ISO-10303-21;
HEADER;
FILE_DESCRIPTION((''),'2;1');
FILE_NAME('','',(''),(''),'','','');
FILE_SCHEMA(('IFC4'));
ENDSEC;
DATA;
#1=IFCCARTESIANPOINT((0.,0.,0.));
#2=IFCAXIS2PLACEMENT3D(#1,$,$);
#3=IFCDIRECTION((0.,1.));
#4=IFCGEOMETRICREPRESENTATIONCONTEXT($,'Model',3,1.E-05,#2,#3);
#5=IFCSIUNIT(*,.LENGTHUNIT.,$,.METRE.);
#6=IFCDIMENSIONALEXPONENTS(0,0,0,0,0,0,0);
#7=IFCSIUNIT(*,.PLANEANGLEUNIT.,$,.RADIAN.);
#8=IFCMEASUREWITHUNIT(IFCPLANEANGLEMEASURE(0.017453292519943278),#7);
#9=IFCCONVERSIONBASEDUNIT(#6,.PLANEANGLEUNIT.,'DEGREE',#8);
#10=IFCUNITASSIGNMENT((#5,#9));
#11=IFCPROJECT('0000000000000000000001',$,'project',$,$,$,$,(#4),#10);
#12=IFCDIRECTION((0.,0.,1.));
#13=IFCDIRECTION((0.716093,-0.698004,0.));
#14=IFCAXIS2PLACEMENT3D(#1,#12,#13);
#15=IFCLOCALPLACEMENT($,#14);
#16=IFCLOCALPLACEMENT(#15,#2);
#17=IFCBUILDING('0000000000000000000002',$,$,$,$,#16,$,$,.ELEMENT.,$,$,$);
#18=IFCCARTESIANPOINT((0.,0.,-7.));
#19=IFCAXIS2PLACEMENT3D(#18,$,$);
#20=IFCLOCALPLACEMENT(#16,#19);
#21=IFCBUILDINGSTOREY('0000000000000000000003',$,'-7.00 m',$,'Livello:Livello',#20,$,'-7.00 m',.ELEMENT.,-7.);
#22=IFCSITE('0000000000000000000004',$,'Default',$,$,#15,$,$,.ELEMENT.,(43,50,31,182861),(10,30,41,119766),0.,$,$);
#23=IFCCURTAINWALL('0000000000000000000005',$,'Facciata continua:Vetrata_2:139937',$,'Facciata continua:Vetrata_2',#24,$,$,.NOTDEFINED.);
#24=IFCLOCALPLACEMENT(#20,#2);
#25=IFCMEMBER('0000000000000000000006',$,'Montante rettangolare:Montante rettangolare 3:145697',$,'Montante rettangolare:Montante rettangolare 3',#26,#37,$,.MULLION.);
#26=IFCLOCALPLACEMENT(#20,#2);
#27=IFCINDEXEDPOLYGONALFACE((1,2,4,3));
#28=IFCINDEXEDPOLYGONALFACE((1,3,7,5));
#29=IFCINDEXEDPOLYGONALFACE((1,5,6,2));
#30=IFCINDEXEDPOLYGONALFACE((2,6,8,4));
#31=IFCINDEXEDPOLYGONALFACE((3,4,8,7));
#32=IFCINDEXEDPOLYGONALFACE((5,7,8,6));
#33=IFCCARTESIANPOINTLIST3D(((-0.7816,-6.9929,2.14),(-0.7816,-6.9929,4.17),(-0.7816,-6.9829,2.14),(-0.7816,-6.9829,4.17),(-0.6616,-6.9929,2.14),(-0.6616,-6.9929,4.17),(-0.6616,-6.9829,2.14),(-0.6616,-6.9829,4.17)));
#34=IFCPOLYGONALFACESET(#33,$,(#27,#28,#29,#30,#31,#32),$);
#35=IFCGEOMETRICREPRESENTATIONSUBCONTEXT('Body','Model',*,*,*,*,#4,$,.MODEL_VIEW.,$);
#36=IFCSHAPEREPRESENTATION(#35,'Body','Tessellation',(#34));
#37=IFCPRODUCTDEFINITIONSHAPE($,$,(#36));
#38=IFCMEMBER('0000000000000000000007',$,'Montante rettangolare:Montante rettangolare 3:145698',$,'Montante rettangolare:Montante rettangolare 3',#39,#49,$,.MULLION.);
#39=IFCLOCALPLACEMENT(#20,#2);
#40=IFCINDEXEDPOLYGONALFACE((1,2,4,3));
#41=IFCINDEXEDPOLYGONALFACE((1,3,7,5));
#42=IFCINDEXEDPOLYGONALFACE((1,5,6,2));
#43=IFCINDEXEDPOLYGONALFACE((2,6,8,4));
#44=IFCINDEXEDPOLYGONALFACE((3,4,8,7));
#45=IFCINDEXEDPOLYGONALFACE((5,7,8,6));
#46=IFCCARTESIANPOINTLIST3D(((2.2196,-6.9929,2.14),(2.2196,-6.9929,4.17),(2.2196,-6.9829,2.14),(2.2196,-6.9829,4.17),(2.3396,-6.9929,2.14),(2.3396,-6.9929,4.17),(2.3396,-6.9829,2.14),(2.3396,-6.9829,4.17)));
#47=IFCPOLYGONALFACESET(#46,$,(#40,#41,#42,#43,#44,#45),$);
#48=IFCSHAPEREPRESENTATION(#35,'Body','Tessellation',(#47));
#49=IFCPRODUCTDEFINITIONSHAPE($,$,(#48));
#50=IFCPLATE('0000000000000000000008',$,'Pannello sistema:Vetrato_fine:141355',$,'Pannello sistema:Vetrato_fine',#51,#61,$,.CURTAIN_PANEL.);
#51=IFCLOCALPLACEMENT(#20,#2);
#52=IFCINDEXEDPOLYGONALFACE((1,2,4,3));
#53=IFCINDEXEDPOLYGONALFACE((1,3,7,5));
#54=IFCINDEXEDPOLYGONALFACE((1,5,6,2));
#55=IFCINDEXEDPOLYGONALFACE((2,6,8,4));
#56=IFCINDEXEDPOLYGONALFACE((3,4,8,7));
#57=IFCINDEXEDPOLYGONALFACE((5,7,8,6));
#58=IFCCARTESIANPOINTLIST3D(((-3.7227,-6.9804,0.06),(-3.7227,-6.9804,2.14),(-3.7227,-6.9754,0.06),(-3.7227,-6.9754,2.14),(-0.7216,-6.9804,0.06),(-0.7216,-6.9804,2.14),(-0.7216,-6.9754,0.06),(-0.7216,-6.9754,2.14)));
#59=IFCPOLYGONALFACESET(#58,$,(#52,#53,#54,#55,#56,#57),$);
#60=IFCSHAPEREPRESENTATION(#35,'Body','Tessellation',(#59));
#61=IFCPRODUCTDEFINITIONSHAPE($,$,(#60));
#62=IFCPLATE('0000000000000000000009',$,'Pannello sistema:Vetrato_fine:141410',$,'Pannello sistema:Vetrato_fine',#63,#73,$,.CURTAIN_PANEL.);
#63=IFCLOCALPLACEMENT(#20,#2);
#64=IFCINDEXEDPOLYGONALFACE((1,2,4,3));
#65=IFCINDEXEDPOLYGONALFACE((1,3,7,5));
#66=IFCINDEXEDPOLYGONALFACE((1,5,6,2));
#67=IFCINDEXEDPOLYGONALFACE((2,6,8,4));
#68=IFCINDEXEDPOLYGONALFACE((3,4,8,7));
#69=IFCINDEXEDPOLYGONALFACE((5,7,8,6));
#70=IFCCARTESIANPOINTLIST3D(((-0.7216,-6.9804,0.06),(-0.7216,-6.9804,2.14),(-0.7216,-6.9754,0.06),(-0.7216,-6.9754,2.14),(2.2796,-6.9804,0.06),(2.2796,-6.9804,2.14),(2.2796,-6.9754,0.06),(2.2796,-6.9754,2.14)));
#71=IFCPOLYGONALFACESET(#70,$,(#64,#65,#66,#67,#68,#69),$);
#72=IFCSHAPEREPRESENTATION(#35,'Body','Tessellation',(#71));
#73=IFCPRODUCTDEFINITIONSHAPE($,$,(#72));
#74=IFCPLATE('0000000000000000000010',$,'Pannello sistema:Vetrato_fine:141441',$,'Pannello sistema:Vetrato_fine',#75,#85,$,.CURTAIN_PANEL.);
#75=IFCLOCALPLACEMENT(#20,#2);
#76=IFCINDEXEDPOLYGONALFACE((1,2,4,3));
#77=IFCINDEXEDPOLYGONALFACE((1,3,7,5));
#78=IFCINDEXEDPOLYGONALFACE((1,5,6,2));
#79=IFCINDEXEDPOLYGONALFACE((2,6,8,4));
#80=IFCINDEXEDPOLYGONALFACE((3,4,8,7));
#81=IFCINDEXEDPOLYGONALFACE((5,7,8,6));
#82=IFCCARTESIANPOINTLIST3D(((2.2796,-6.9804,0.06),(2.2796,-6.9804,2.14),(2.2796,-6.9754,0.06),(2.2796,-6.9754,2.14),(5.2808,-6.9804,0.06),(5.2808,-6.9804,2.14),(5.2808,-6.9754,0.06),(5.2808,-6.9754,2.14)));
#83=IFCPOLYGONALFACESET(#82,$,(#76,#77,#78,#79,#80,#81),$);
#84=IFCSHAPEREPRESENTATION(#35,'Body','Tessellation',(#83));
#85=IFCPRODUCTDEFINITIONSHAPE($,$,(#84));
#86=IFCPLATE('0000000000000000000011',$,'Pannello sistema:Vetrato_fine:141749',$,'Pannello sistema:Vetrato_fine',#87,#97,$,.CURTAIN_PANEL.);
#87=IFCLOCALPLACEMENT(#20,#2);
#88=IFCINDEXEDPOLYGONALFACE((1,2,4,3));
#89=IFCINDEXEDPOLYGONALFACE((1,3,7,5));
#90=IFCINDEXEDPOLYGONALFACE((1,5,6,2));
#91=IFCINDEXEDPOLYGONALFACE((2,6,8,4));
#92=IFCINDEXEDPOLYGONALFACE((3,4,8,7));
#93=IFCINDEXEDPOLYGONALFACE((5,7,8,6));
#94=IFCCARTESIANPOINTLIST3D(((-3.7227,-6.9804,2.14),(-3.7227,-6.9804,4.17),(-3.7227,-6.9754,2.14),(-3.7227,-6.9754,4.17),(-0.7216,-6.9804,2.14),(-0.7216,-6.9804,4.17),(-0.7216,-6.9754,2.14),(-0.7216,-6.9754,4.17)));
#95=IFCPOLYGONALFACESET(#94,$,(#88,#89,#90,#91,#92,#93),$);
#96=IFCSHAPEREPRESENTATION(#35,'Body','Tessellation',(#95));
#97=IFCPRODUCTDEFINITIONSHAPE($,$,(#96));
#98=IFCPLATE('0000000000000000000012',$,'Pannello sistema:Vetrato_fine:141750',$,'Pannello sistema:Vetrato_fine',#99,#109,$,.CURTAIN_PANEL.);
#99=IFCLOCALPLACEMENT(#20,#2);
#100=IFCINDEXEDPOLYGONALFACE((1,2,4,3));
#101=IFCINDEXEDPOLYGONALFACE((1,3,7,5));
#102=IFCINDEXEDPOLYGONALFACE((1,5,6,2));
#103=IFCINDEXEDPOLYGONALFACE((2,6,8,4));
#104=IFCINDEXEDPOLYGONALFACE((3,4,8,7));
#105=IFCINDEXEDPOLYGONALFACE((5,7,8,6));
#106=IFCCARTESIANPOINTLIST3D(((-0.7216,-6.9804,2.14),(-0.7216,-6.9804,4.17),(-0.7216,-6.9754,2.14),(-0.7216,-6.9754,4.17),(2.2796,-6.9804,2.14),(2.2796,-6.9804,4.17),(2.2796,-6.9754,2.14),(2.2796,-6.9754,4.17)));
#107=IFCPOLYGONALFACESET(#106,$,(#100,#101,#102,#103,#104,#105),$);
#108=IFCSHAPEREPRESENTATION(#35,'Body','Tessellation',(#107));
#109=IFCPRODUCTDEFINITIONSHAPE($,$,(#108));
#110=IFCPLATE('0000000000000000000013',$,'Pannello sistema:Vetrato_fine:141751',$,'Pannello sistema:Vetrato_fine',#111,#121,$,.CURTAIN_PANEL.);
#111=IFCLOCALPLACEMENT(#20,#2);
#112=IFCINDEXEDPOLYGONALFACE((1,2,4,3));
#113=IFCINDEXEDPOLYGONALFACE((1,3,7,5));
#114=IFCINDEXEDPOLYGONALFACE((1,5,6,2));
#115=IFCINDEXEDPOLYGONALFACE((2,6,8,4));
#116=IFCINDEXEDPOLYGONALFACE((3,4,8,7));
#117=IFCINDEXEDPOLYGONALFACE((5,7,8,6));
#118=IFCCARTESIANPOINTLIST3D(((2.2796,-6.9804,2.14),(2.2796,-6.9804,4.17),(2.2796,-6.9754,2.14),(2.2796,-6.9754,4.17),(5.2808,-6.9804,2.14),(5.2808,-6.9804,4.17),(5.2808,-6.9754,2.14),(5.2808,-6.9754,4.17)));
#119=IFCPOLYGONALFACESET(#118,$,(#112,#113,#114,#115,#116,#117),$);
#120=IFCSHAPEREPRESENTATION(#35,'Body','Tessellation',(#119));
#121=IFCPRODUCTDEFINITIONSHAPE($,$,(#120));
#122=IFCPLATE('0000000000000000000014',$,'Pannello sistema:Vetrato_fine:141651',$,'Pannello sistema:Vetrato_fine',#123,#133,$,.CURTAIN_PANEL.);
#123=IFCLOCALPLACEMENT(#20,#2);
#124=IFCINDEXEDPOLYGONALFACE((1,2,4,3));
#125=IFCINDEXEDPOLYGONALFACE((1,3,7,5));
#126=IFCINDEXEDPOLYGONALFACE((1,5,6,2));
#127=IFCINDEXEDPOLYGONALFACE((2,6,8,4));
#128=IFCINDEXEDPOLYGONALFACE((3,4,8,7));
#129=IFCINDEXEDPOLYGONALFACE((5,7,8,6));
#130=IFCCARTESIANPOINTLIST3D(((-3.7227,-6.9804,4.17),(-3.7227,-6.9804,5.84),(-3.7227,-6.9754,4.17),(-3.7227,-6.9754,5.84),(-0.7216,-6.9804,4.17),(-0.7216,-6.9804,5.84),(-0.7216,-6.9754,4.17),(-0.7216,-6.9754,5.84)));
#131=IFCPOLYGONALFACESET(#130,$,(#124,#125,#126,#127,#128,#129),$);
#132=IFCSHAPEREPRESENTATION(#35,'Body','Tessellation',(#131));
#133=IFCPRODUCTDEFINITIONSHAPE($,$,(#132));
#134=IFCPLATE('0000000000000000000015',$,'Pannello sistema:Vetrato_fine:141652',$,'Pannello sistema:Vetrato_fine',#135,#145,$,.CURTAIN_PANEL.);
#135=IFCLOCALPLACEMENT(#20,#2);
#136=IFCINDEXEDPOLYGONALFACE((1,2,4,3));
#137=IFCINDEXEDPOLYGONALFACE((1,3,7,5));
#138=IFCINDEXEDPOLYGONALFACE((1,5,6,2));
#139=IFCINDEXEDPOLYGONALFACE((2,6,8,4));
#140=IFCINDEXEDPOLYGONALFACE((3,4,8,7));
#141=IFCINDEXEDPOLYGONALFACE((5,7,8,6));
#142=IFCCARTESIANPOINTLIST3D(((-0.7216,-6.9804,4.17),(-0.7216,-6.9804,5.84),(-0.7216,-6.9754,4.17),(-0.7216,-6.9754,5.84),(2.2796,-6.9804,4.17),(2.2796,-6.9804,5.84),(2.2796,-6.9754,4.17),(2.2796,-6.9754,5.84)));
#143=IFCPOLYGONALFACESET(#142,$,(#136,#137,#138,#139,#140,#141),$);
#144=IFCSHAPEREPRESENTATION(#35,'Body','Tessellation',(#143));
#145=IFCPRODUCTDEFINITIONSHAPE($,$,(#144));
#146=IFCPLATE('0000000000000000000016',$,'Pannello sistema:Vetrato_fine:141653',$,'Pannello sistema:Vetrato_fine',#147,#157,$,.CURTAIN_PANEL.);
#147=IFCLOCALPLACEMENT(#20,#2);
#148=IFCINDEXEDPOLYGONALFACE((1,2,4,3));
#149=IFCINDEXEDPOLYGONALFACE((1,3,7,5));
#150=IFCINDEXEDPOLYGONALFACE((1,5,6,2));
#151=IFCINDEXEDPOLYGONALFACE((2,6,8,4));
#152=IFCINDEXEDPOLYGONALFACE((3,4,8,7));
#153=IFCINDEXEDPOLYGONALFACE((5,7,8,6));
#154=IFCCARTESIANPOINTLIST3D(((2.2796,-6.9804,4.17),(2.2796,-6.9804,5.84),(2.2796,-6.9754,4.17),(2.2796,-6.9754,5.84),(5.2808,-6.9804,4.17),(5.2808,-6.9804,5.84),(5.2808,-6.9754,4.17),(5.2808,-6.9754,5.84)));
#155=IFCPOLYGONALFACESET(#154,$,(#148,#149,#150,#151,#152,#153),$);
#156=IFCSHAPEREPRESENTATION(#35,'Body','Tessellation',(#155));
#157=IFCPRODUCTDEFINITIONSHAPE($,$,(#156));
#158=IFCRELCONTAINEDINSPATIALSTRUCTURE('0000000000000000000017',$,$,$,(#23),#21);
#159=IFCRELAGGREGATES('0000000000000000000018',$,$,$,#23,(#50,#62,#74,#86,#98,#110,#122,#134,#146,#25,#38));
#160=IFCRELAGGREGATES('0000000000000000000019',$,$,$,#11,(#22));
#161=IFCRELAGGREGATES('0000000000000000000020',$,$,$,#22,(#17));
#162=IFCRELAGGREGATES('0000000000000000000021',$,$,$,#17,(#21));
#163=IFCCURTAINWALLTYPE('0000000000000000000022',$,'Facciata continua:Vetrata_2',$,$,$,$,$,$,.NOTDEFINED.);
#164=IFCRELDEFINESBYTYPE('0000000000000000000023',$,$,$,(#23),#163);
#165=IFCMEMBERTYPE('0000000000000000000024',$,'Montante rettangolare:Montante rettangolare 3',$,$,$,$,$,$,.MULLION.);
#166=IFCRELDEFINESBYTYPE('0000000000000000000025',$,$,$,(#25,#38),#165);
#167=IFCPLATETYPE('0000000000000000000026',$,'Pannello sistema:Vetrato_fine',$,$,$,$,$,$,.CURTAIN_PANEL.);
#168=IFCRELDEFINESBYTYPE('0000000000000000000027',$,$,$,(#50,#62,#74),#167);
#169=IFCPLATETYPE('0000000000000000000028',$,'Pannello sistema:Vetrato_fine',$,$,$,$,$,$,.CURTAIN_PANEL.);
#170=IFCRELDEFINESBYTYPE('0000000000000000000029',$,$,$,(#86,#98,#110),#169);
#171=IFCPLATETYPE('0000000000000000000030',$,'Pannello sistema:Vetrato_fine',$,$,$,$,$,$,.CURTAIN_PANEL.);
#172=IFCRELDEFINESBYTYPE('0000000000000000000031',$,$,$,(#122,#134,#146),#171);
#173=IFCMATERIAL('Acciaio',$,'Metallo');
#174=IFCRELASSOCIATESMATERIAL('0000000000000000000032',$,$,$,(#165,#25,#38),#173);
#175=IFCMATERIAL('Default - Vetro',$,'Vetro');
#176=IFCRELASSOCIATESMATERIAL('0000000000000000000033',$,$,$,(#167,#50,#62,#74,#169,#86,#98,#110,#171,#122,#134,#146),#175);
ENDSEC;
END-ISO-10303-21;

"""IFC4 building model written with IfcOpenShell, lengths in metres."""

from ifc_helpers import new_model, entity, si_unit, converted_unit, direction, frame, origin, place, context, subcontext, project, spatial, indexed_curve, outline, extrude, source, transform, mapped, material, type_object, type_shapes, element, aggregate, save


model = new_model("IFC4")

# Units and contexts
model_context = context("Model", 3, precision=1e-05, world=origin(), true_north=direction((0.0, 1.0)))
body_context = subcontext(model_context, "Body", "Model", "MODEL_VIEW")
ifc_project = project(units=[si_unit("LENGTHUNIT", "METRE"), converted_unit("PLANEANGLEUNIT", "DEGREE", entity("IfcPlaneAngleMeasure", 0.017453292519943278), si_unit("PLANEANGLEUNIT", "RADIAN"), dimensions=[0, 0, 0, 0, 0, 0, 0])], contexts=[model_context])

# Site, building, storey
site_placement = place(None, frame((0.0, 0.0, 0.0), z_axis=(0.0, 0.0, 1.0), x_axis=(0.716093, -0.698004, 0.0)))
site = spatial("IfcSite", under=ifc_project, at=site_placement, Name="Default", CompositionType="ELEMENT", RefLatitude=(43, 50, 31, 182861), RefLongitude=(10, 30, 41, 119766), RefElevation=0.0)
building_placement = place(site_placement, origin())
building = spatial("IfcBuilding", under=site, at=building_placement, CompositionType="ELEMENT")
storey_placement = place(building_placement, frame((0.0, 0.0, -7.0)))
storey = spatial("IfcBuildingStorey", under=building, at=storey_placement, Name="-7.00 m", ObjectType="Livello:Livello", LongName="-7.00 m", CompositionType="ELEMENT", Elevation=-7.0)

# Curtain wall, members, plates
curtain_wall_type = type_object("IfcCurtainWallType", Name="Facciata continua:Vetrata_2", PredefinedType="NOTDEFINED")
curtain_wall_placement = place(storey_placement, frame((0.0, 0.0, 7.0)))
curtain_wall = element("IfcCurtainWall", 1, at=curtain_wall_placement, inside=storey, type_object=curtain_wall_type, Name="Facciata continua:Vetrata_2:139937", ObjectType="Facciata continua:Vetrata_2", PredefinedType="NOTDEFINED")
ifc_material_1 = material(Name="Acciaio", Category="Metallo")
member_type_1 = type_object("IfcMemberType", Name="Montante rettangolare:Montante rettangolare 3", PredefinedType="MULLION", material=ifc_material_1)
shared_shape_1 = source(origin(), body_context, "Body", "SweptSolid", [
    extrude(outline(indexed_curve([(-0.06, -0.005), (0.06, -0.005), (0.06, 0.005), (-0.06, 0.005), (-0.06, -0.005)], self_intersect=False)), frame((0.0, 0.01, -2.03), z_axis=(0.0, 0.0, 1.0), x_axis=(-1.0, 0.0, 0.0)), (0.0, 0.0, 1.0), 2.03),
])
type_shapes(member_type_1, [shared_shape_1])
member_1_placement = place(curtain_wall_placement, frame((-0.7216, -6.9779, -4.86), z_axis=(0.0, 0.0, -1.0), x_axis=(1.0, 0.0, 0.0)))
member_1 = element("IfcMember", 2, at=member_1_placement, type_object=member_type_1, material=ifc_material_1, Name="Montante rettangolare:Montante rettangolare 3:145697", ObjectType="Montante rettangolare:Montante rettangolare 3", PredefinedType="MULLION", context=body_context, shape_type="MappedRepresentation", body=[
    mapped(shared_shape_1, transform((0.0, 0.0, 0.0), scale=1.0)),
])
member_2_placement = place(curtain_wall_placement, frame((2.2796, -6.9779, -4.86), z_axis=(0.0, 0.0, -1.0), x_axis=(1.0, 0.0, 0.0)))
member_2 = element("IfcMember", 3, at=member_2_placement, type_object=member_type_1, material=ifc_material_1, Name="Montante rettangolare:Montante rettangolare 3:145698", ObjectType="Montante rettangolare:Montante rettangolare 3", PredefinedType="MULLION", context=body_context, shape_type="MappedRepresentation", body=[
    mapped(shared_shape_1, transform((0.0, 0.0, 0.0), scale=1.0)),
])
ifc_material_2 = material(Name="Default - Vetro", Category="Vetro")
plate_type_1 = type_object("IfcPlateType", Name="Pannello sistema:Vetrato_fine", PredefinedType="CURTAIN_PANEL", material=ifc_material_2)
shared_shape_2 = source(origin(), body_context, "Body", "SweptSolid", [
    extrude(outline(indexed_curve([(-0.0025, -1.5006), (0.0025, -1.5006), (0.0025, 1.5006), (-0.0025, 1.5006), (-0.0025, -1.5006)], self_intersect=False)), frame((0.0, 0.0, 0.0), z_axis=(0.0, 0.0, 1.0), x_axis=(0.0, 1.0, 0.0)), (0.0, 0.0, 1.0), 2.08),
])
type_shapes(plate_type_1, [shared_shape_2])
plate_1_placement = place(curtain_wall_placement, frame((-2.2221, -6.9779, -6.94)))
plate_1 = element("IfcPlate", 4, at=plate_1_placement, type_object=plate_type_1, material=ifc_material_2, Name="Pannello sistema:Vetrato_fine:141355", ObjectType="Pannello sistema:Vetrato_fine", PredefinedType="CURTAIN_PANEL", context=body_context, shape_type="MappedRepresentation", body=[
    mapped(shared_shape_2, transform((0.0, 0.0, 0.0), scale=1.0)),
])
plate_2_placement = place(curtain_wall_placement, frame((0.779, -6.9779, -6.94)))
plate_2 = element("IfcPlate", 5, at=plate_2_placement, type_object=plate_type_1, material=ifc_material_2, Name="Pannello sistema:Vetrato_fine:141410", ObjectType="Pannello sistema:Vetrato_fine", PredefinedType="CURTAIN_PANEL", context=body_context, shape_type="MappedRepresentation", body=[
    mapped(shared_shape_2, transform((0.0, 0.0, 0.0), scale=1.0)),
])
plate_3_placement = place(curtain_wall_placement, frame((3.7802, -6.9779, -6.94)))
plate_3 = element("IfcPlate", 6, at=plate_3_placement, type_object=plate_type_1, material=ifc_material_2, Name="Pannello sistema:Vetrato_fine:141441", ObjectType="Pannello sistema:Vetrato_fine", PredefinedType="CURTAIN_PANEL", context=body_context, shape_type="MappedRepresentation", body=[
    mapped(shared_shape_2, transform((0.0, 0.0, 0.0), scale=1.0)),
])
plate_type_2 = type_object("IfcPlateType", Name="Pannello sistema:Vetrato_fine", PredefinedType="CURTAIN_PANEL", material=ifc_material_2)
shared_shape_3 = source(origin(), body_context, "Body", "SweptSolid", [
    extrude(outline(indexed_curve([(-0.0025, -1.5006), (0.0025, -1.5006), (0.0025, 1.5006), (-0.0025, 1.5006), (-0.0025, -1.5006)], self_intersect=False)), frame((0.0, 0.0, 0.0), z_axis=(0.0, 0.0, 1.0), x_axis=(0.0, 1.0, 0.0)), (0.0, 0.0, 1.0), 2.03),
])
type_shapes(plate_type_2, [shared_shape_3])
plate_4_placement = place(curtain_wall_placement, frame((-2.2221, -6.9779, -4.86)))
plate_4 = element("IfcPlate", 7, at=plate_4_placement, type_object=plate_type_2, material=ifc_material_2, Name="Pannello sistema:Vetrato_fine:141749", ObjectType="Pannello sistema:Vetrato_fine", PredefinedType="CURTAIN_PANEL", context=body_context, shape_type="MappedRepresentation", body=[
    mapped(shared_shape_3, transform((0.0, 0.0, 0.0), scale=1.0)),
])
plate_5_placement = place(curtain_wall_placement, frame((0.779, -6.9779, -4.86)))
plate_5 = element("IfcPlate", 8, at=plate_5_placement, type_object=plate_type_2, material=ifc_material_2, Name="Pannello sistema:Vetrato_fine:141750", ObjectType="Pannello sistema:Vetrato_fine", PredefinedType="CURTAIN_PANEL", context=body_context, shape_type="MappedRepresentation", body=[
    mapped(shared_shape_3, transform((0.0, 0.0, 0.0), scale=1.0)),
])
plate_6_placement = place(curtain_wall_placement, frame((3.7802, -6.9779, -4.86)))
plate_6 = element("IfcPlate", 9, at=plate_6_placement, type_object=plate_type_2, material=ifc_material_2, Name="Pannello sistema:Vetrato_fine:141751", ObjectType="Pannello sistema:Vetrato_fine", PredefinedType="CURTAIN_PANEL", context=body_context, shape_type="MappedRepresentation", body=[
    mapped(shared_shape_3, transform((0.0, 0.0, 0.0), scale=1.0)),
])
plate_type_3 = type_object("IfcPlateType", Name="Pannello sistema:Vetrato_fine", PredefinedType="CURTAIN_PANEL", material=ifc_material_2)
shared_shape_4 = source(origin(), body_context, "Body", "SweptSolid", [
    extrude(outline(indexed_curve([(-0.0025, -1.5006), (0.0025, -1.5006), (0.0025, 1.5006), (-0.0025, 1.5006), (-0.0025, -1.5006)], self_intersect=False)), frame((0.0, 0.0, 0.0), z_axis=(0.0, 0.0, 1.0), x_axis=(0.0, 1.0, 0.0)), (0.0, 0.0, 1.0), 1.67),
])
type_shapes(plate_type_3, [shared_shape_4])
plate_7_placement = place(curtain_wall_placement, frame((-2.2221, -6.9779, -2.83)))
plate_7 = element("IfcPlate", 10, at=plate_7_placement, type_object=plate_type_3, material=ifc_material_2, Name="Pannello sistema:Vetrato_fine:141651", ObjectType="Pannello sistema:Vetrato_fine", PredefinedType="CURTAIN_PANEL", context=body_context, shape_type="MappedRepresentation", body=[
    mapped(shared_shape_4, transform((0.0, 0.0, 0.0), scale=1.0)),
])
plate_8_placement = place(curtain_wall_placement, frame((0.779, -6.9779, -2.83)))
plate_8 = element("IfcPlate", 11, at=plate_8_placement, type_object=plate_type_3, material=ifc_material_2, Name="Pannello sistema:Vetrato_fine:141652", ObjectType="Pannello sistema:Vetrato_fine", PredefinedType="CURTAIN_PANEL", context=body_context, shape_type="MappedRepresentation", body=[
    mapped(shared_shape_4, transform((0.0, 0.0, 0.0), scale=1.0)),
])
plate_9_placement = place(curtain_wall_placement, frame((3.7802, -6.9779, -2.83)))
plate_9 = element("IfcPlate", 12, at=plate_9_placement, type_object=plate_type_3, material=ifc_material_2, Name="Pannello sistema:Vetrato_fine:141653", ObjectType="Pannello sistema:Vetrato_fine", PredefinedType="CURTAIN_PANEL", context=body_context, shape_type="MappedRepresentation", body=[
    mapped(shared_shape_4, transform((0.0, 0.0, 0.0), scale=1.0)),
])
aggregate(curtain_wall, [plate_1, plate_2, plate_3, plate_4, plate_5, plate_6, plate_7, plate_8, plate_9, member_1, member_2])

save(model, "model.ifc")
